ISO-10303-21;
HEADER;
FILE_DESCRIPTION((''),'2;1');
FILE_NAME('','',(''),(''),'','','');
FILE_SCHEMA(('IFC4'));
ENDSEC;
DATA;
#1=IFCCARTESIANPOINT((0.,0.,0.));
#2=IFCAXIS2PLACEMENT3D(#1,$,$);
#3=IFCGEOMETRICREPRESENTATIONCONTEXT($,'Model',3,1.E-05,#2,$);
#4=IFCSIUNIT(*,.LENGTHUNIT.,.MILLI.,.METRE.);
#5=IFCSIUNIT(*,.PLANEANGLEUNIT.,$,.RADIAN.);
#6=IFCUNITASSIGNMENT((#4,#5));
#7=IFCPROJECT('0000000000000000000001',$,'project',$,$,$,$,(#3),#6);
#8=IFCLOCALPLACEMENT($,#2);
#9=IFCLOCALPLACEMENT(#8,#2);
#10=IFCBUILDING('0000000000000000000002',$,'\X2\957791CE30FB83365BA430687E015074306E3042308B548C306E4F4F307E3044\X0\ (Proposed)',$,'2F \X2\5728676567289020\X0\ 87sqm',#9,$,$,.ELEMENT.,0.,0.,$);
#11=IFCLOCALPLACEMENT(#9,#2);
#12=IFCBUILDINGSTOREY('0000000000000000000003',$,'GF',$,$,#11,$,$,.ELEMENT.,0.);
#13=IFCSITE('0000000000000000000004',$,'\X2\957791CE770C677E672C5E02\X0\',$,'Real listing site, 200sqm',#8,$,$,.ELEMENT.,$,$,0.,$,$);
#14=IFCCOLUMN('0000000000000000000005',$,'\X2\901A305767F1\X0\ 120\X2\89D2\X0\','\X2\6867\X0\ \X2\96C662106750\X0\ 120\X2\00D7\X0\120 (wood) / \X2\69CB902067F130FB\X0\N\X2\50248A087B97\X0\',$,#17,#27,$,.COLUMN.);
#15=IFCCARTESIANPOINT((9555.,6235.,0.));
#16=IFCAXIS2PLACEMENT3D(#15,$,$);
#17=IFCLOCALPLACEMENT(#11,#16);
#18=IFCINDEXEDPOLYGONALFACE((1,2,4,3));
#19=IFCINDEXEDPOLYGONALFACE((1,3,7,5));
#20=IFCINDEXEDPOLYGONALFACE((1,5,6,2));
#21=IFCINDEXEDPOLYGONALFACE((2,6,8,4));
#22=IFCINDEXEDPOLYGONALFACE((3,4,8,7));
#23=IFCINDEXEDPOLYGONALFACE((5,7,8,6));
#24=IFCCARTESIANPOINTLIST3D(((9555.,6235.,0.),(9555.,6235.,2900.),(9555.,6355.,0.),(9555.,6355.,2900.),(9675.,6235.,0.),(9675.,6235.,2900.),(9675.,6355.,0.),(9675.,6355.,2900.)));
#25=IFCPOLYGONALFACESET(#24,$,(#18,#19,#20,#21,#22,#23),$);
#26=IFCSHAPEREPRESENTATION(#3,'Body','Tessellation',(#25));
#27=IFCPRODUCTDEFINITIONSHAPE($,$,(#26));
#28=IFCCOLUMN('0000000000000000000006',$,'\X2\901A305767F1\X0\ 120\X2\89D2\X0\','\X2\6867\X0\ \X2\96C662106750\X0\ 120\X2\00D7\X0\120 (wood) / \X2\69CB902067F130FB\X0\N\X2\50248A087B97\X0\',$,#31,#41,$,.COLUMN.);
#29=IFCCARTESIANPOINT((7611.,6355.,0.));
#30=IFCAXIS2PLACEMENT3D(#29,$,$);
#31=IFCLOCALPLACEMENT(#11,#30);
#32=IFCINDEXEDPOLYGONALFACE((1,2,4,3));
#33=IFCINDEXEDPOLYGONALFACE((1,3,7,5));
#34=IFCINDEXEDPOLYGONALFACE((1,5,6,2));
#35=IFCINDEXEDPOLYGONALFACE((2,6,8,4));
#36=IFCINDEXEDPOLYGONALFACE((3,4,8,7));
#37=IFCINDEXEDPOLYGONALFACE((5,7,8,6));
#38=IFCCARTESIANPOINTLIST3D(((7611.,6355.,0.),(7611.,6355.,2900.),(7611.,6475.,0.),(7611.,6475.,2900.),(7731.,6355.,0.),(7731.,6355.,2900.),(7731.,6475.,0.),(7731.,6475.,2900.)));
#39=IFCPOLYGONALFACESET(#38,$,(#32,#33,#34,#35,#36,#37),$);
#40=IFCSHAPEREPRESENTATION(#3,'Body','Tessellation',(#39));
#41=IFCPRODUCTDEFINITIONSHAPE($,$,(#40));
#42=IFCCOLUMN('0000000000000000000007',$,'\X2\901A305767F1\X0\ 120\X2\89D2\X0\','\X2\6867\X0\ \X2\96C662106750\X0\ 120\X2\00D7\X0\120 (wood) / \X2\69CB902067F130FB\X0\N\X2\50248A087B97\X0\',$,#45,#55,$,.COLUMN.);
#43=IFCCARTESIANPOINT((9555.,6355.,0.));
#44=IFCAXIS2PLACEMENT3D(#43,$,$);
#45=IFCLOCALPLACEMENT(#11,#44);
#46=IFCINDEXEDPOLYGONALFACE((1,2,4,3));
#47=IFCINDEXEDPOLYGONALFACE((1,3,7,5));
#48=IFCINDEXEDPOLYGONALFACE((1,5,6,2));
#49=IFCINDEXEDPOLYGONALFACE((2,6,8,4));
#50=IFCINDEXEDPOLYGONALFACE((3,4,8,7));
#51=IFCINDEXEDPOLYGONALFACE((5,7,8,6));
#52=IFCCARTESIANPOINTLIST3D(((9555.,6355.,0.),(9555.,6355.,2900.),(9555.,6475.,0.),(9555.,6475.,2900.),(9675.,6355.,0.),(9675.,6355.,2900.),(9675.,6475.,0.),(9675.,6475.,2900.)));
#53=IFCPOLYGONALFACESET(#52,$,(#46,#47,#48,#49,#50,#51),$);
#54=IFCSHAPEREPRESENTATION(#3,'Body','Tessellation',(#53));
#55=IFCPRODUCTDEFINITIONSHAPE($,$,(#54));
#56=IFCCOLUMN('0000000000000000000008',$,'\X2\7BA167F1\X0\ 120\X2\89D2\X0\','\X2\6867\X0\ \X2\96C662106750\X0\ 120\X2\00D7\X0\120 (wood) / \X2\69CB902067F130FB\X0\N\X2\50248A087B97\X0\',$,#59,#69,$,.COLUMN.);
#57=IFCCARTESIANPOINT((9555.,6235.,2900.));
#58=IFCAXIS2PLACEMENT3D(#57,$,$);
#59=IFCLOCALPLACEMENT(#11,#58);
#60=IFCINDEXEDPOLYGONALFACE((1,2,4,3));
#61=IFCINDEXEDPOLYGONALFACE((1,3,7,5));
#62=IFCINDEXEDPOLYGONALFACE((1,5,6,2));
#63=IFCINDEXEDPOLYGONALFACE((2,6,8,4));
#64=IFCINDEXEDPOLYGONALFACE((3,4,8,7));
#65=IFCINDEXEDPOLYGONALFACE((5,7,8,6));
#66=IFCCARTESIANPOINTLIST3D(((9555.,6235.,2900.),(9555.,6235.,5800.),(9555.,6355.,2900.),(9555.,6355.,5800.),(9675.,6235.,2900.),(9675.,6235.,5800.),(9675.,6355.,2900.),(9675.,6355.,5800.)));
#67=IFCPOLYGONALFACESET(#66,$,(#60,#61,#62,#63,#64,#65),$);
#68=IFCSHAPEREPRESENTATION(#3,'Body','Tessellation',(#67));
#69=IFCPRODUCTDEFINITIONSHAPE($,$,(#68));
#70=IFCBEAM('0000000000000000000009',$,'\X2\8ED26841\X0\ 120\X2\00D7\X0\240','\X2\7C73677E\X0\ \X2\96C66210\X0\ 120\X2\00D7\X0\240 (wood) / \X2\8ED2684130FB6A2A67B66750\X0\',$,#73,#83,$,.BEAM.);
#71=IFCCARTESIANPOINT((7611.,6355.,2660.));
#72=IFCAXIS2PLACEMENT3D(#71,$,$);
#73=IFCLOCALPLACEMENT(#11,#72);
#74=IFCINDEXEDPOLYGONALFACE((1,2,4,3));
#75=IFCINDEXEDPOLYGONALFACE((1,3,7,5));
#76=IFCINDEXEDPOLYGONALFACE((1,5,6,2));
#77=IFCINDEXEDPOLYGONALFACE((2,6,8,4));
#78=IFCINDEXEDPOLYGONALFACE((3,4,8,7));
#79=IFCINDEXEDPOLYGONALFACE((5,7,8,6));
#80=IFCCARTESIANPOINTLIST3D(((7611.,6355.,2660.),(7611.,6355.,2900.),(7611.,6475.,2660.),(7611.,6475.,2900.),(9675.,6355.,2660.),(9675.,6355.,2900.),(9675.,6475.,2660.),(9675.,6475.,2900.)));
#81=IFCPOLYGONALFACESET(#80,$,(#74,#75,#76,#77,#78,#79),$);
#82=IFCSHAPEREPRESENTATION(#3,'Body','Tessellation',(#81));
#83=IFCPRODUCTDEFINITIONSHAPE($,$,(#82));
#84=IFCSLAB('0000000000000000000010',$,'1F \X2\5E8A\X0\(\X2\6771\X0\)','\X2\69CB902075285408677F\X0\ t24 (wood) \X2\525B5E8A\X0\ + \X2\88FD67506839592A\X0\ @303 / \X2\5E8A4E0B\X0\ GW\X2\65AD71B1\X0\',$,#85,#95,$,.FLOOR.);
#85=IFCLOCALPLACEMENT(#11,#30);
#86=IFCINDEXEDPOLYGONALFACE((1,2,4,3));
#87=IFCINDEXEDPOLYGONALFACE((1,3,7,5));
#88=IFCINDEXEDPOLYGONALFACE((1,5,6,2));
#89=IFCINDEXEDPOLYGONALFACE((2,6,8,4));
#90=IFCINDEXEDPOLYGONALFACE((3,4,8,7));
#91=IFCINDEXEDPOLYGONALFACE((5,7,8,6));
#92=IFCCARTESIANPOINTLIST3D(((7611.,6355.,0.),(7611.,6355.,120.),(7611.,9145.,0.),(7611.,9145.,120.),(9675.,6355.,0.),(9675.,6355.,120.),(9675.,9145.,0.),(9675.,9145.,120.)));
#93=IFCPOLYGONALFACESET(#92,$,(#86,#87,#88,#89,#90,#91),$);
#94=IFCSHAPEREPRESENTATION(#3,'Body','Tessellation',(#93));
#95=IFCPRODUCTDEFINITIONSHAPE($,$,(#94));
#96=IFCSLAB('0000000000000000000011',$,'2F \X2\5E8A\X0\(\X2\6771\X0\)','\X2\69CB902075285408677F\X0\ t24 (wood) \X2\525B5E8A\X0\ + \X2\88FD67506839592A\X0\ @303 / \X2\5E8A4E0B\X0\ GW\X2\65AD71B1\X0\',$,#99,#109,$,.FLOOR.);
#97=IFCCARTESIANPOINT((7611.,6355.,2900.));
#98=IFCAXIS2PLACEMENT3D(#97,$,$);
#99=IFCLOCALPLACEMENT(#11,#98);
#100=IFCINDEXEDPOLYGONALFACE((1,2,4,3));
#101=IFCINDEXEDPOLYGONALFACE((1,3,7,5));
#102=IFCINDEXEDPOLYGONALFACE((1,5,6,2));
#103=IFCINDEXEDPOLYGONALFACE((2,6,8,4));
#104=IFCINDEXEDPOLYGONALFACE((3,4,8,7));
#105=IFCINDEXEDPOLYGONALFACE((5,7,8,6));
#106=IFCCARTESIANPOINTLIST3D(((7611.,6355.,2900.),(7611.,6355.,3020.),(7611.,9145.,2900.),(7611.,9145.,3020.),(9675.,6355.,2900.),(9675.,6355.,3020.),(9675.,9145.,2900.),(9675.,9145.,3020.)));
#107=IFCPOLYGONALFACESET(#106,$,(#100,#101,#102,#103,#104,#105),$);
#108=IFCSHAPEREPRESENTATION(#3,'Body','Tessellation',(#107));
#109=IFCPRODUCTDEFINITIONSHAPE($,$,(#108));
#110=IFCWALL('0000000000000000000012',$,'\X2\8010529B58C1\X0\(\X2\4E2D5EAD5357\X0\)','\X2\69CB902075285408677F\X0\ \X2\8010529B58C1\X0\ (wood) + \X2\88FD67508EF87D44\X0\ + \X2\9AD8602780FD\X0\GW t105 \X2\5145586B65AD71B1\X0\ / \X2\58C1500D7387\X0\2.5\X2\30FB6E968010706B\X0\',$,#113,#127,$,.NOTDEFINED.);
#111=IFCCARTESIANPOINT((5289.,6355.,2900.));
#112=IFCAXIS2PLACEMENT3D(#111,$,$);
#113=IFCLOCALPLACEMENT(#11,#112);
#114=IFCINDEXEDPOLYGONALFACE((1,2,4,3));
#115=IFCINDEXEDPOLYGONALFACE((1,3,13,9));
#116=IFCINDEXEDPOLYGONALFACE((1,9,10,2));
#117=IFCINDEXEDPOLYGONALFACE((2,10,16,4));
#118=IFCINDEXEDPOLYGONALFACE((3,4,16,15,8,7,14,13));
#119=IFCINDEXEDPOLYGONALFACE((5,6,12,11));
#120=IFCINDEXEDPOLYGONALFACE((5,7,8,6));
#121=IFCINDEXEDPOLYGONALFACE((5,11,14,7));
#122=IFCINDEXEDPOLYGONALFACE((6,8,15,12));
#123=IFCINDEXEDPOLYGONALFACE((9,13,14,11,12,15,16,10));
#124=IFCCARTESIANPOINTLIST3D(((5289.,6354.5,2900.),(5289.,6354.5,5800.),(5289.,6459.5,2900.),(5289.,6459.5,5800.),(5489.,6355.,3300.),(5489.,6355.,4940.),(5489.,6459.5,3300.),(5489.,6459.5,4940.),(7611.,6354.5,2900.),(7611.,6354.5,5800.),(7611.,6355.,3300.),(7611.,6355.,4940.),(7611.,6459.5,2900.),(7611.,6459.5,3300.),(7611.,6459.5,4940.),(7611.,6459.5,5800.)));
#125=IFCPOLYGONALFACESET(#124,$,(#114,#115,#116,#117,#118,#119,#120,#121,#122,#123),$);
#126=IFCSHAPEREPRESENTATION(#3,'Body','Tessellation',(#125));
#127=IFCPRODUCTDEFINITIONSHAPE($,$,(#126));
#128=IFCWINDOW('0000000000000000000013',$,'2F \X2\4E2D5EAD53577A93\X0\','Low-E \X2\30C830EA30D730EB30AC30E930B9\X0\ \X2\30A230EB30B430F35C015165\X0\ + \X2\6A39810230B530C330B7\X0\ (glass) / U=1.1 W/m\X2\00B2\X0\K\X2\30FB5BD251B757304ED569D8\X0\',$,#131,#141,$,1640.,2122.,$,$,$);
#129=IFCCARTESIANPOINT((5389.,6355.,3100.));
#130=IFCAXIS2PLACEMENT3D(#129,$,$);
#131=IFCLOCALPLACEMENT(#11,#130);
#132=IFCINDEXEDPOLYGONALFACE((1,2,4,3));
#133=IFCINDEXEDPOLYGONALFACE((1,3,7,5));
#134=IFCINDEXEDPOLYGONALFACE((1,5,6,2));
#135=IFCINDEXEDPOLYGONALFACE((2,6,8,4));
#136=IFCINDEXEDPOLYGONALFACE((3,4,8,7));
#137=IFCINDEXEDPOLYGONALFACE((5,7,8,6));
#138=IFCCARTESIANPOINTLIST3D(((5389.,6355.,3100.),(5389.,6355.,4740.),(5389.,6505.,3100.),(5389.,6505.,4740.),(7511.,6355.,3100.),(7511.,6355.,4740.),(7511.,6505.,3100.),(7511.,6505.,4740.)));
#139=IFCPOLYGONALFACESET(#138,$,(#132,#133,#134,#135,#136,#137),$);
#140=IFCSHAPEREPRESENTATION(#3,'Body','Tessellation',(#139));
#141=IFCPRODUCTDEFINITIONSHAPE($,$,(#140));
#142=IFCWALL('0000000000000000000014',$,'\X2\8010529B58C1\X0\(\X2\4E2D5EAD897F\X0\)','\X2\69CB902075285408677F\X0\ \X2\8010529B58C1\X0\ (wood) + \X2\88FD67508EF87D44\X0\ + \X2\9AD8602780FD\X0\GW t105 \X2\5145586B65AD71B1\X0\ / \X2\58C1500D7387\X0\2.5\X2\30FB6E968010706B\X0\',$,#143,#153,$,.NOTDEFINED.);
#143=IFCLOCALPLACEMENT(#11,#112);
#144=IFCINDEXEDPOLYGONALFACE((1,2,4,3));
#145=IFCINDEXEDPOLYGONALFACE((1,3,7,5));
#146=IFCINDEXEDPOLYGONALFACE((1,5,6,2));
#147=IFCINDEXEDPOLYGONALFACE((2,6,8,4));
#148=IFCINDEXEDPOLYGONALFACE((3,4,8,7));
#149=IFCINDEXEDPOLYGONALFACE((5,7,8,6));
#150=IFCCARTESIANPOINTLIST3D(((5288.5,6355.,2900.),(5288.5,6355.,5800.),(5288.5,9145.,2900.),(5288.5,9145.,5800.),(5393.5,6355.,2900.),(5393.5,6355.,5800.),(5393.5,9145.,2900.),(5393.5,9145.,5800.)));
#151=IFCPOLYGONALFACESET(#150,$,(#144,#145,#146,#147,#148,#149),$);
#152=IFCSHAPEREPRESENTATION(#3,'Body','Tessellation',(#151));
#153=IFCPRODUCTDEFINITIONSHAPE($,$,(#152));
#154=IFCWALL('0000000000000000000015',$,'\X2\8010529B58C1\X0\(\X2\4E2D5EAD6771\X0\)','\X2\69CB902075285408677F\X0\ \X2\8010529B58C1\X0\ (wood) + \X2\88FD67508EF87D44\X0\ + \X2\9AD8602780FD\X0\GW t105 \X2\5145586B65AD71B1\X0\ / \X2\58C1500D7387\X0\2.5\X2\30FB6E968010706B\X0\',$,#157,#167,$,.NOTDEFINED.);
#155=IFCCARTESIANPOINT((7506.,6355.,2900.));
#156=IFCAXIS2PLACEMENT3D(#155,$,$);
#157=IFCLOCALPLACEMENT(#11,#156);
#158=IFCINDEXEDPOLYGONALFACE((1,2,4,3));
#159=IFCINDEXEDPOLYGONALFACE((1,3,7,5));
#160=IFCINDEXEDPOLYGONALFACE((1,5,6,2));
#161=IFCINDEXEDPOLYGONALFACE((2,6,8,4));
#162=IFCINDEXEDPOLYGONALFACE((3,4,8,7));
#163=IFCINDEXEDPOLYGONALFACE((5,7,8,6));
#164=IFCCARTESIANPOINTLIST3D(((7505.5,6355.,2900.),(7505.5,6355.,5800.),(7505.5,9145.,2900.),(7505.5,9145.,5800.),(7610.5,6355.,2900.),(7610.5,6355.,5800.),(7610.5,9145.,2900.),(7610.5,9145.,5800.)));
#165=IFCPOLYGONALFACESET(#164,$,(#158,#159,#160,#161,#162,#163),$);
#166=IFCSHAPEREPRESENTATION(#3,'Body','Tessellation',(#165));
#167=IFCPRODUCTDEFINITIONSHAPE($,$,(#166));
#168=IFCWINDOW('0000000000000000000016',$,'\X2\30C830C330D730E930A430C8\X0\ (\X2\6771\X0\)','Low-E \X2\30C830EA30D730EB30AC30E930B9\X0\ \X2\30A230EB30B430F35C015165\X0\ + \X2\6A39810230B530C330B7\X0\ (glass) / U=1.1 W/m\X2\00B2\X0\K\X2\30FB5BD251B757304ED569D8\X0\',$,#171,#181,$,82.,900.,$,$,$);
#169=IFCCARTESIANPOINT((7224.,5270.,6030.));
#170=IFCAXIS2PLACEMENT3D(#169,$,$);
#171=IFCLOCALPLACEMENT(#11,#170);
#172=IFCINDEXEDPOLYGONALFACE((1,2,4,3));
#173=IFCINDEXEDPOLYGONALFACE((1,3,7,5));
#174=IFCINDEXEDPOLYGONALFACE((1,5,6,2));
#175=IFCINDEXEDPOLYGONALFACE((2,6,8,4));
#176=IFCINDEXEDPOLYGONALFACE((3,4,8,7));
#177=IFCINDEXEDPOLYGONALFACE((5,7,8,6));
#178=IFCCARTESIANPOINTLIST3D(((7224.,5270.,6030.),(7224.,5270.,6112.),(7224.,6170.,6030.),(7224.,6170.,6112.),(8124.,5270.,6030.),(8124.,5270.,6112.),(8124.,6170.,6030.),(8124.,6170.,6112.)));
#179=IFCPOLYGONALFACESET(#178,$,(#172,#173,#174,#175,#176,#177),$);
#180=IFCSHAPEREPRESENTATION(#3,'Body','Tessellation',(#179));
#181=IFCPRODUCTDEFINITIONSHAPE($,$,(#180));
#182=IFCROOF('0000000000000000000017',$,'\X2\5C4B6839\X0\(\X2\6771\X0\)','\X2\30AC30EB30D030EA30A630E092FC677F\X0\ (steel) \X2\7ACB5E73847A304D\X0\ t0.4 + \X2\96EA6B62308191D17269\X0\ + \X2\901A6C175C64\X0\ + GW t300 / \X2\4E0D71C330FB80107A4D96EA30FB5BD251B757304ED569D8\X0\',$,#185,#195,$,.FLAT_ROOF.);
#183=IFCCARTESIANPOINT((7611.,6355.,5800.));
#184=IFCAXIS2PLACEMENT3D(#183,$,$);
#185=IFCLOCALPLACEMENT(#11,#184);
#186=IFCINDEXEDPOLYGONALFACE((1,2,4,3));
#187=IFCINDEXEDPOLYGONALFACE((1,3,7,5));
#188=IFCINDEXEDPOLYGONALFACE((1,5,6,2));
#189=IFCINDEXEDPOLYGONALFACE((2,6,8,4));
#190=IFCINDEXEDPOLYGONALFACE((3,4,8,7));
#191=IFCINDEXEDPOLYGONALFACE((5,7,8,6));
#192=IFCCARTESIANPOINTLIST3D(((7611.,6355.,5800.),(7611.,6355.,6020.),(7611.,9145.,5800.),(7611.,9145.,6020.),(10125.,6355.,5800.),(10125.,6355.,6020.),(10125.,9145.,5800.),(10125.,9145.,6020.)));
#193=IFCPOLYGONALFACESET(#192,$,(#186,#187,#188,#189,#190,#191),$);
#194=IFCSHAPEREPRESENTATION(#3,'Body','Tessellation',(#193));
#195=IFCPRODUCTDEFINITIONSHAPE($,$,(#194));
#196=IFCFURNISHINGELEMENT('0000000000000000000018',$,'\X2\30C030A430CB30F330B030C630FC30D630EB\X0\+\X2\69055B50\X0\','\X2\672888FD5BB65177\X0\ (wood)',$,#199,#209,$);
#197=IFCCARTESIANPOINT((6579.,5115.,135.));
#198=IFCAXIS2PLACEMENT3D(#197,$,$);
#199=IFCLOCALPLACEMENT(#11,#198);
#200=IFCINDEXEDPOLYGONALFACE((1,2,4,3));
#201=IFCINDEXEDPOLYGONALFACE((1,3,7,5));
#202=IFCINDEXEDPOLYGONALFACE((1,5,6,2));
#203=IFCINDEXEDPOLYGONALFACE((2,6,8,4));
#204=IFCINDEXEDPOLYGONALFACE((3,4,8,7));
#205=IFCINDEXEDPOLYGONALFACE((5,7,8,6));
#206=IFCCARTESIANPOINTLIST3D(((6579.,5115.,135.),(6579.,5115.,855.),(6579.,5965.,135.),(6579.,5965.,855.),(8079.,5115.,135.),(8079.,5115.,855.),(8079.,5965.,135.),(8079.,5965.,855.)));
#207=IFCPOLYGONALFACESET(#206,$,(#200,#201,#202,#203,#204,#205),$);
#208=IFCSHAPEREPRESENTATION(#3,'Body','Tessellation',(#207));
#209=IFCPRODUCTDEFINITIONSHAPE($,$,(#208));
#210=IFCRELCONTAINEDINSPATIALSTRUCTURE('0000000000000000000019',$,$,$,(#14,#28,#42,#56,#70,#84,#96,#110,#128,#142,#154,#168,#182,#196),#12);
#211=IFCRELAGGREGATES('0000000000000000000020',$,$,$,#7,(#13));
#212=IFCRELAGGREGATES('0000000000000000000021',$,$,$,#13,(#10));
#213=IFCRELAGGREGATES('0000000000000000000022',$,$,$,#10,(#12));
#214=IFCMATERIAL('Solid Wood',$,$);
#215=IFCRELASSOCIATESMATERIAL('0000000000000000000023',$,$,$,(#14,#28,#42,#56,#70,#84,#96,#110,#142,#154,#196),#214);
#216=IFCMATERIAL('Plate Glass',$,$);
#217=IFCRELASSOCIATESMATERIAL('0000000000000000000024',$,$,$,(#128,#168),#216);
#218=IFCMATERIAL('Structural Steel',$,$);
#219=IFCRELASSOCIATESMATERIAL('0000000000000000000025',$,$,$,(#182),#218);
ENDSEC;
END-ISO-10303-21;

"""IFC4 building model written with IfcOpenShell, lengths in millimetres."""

from ifc_helpers import new_model, si_unit, frame, frame_2d, origin, place, context, project, spatial, rectangle, extrude, material, element, fill, save


model = new_model("IFC4")

# Units and contexts
model_context = context("Model", 3, precision=1e-05, world=origin())
ifc_project = project(units=[si_unit("LENGTHUNIT", "METRE", prefix="MILLI"), si_unit("PLANEANGLEUNIT", "RADIAN")], contexts=[model_context])

# Site, building, storey
site_placement = place(None, origin())
site = spatial("IfcSite", under=ifc_project, at=site_placement, Name="長野県松本市", ObjectType="Real listing site, 200sqm", CompositionType="ELEMENT", RefElevation=0.0)
building_placement = place(site_placement, origin())
building = spatial("IfcBuilding", under=site, at=building_placement, Name="長野・茶室と縁側のある和の住まい (Proposed)", ObjectType="2F 在来木造 87sqm", CompositionType="ELEMENT", ElevationOfRefHeight=0.0, ElevationOfTerrain=0.0)
storey_placement = place(building_placement, origin())
storey = spatial("IfcBuildingStorey", under=building, at=storey_placement, Name="GF", CompositionType="ELEMENT", Elevation=0.0)

# Columns
ifc_material_1 = material(Name="Solid Wood")
column_1_placement = place(storey_placement, frame((9555.0, 6235.0, 0.0)))
element("IfcColumn", 1, at=column_1_placement, inside=storey, material=ifc_material_1, Name="通し柱 120角", Description="桧 集成材 120×120 (wood) / 構造柱・N値計算", PredefinedType="COLUMN", context=model_context, shape_type="SweptSolid", body=[
    extrude(rectangle(XDim=120.0, YDim=120.0, at=frame_2d((60.0, 60.0))), frame((9555.0, 6235.0, 0.0)), (0.0, 0.0, 1.0), 2900.0),
])
column_2_placement = place(storey_placement, frame((7611.0, 6355.0, 0.0)))
element("IfcColumn", 2, at=column_2_placement, inside=storey, material=ifc_material_1, Name="通し柱 120角", Description="桧 集成材 120×120 (wood) / 構造柱・N値計算", PredefinedType="COLUMN", context=model_context, shape_type="SweptSolid", body=[
    extrude(rectangle(XDim=120.0, YDim=120.0, at=frame_2d((60.0, 60.0))), frame((7611.0, 6355.0, 0.0)), (0.0, 0.0, 1.0), 2900.0),
])
column_3_placement = place(storey_placement, frame((9555.0, 6355.0, 0.0)))
element("IfcColumn", 3, at=column_3_placement, inside=storey, material=ifc_material_1, Name="通し柱 120角", Description="桧 集成材 120×120 (wood) / 構造柱・N値計算", PredefinedType="COLUMN", context=model_context, shape_type="SweptSolid", body=[
    extrude(rectangle(XDim=120.0, YDim=120.0, at=frame_2d((60.0, 60.0))), frame((9555.0, 6355.0, 0.0)), (0.0, 0.0, 1.0), 2900.0),
])
column_4_placement = place(storey_placement, frame((9555.0, 6235.0, 2900.0)))
element("IfcColumn", 4, at=column_4_placement, inside=storey, material=ifc_material_1, Name="管柱 120角", Description="桧 集成材 120×120 (wood) / 構造柱・N値計算", PredefinedType="COLUMN", context=model_context, shape_type="SweptSolid", body=[
    extrude(rectangle(XDim=120.0, YDim=120.0, at=frame_2d((60.0, 60.0))), frame((9555.0, 6235.0, 2900.0)), (0.0, 0.0, 1.0), 2900.0),
])

# Beam
beam_1_placement = place(storey_placement, frame((7611.0, 6355.0, 2660.0)))
element("IfcBeam", 5, at=beam_1_placement, inside=storey, material=ifc_material_1, Name="軒桁 120×240", Description="米松 集成 120×240 (wood) / 軒桁・横架材", PredefinedType="BEAM", context=model_context, shape_type="SweptSolid", body=[
    extrude(rectangle(XDim=2064.0, YDim=120.0, at=frame_2d((1032.0, 60.0))), frame((7611.0, 6355.0, 2660.0)), (0.0, 0.0, 1.0), 240.0),
])

# Slabs
slab_1_placement = place(storey_placement, frame((7611.0, 6355.0, 0.0)))
element("IfcSlab", 6, at=slab_1_placement, inside=storey, material=ifc_material_1, Name="1F 床(東)", Description="構造用合板 t24 (wood) 剛床 + 製材根太 @303 / 床下 GW断熱", PredefinedType="FLOOR", context=model_context, shape_type="SweptSolid", body=[
    extrude(rectangle(XDim=2064.0, YDim=2790.0, at=frame_2d((1032.0, 1395.0))), frame((7611.0, 6355.0, 0.0)), (0.0, 0.0, 1.0), 120.0),
])
slab_2_placement = place(storey_placement, frame((7611.0, 6355.0, 2900.0)))
element("IfcSlab", 7, at=slab_2_placement, inside=storey, material=ifc_material_1, Name="2F 床(東)", Description="構造用合板 t24 (wood) 剛床 + 製材根太 @303 / 床下 GW断熱", PredefinedType="FLOOR", context=model_context, shape_type="SweptSolid", body=[
    extrude(rectangle(XDim=2064.0, YDim=2790.0, at=frame_2d((1032.0, 1395.0))), frame((7611.0, 6355.0, 2900.0)), (0.0, 0.0, 1.0), 120.0),
])

# Wall, opening, window
wall_1_placement = place(storey_placement, frame((5289.0, 6355.0, 2900.0)))
wall_1 = element("IfcWall", 8, at=wall_1_placement, inside=storey, material=ifc_material_1, Name="耐力壁(中庭南)", Description="構造用合板 耐力壁 (wood) + 製材軸組 + 高性能GW t105 充填断熱 / 壁倍率2.5・準耐火", PredefinedType="NOTDEFINED", context=model_context, shape_type="SweptSolid", body=[
    extrude(rectangle(XDim=2322.0, YDim=105.0, at=frame_2d((1161.0, 52.0))), frame((5289.0, 6355.0, 2900.0)), (0.0, 0.0, 1.0), 2900.0),
])
opening_placement = place(storey_placement, frame((5389.0, 6355.0, 3100.0)))
opening = element("IfcOpeningElement", 9, at=opening_placement, cuts=wall_1, PredefinedType="NOTDEFINED", context=model_context, shape_type="SweptSolid", body=[
    extrude(rectangle(XDim=2122.0, YDim=150.0, at=frame_2d((1061.0, 75.0))), frame((5389.0, 6355.0, 3100.0)), (0.0, 0.0, 1.0), 1640.0),
])
ifc_material_2 = material(Name="Plate Glass")
window_1_placement = place(storey_placement, frame((5389.0, 6355.0, 3100.0)))
window_1 = element("IfcWindow", 10, at=window_1_placement, inside=storey, material=ifc_material_2, Name="2F 中庭南窓", Description="Low-E トリプルガラス アルゴン封入 + 樹脂サッシ (glass) / U=1.1 W/m²K・寒冷地仕様", OverallHeight=1640.0, OverallWidth=2122.0, context=model_context, shape_type="SweptSolid", body=[
    extrude(rectangle(XDim=2122.0, YDim=150.0, at=frame_2d((1061.0, 75.0))), frame((5389.0, 6355.0, 3100.0)), (0.0, 0.0, 1.0), 1640.0),
])
fill(opening, window_1)

# Walls
wall_2_placement = place(storey_placement, frame((5289.0, 6355.0, 2900.0)))
element("IfcWall", 11, at=wall_2_placement, inside=storey, material=ifc_material_1, Name="耐力壁(中庭西)", Description="構造用合板 耐力壁 (wood) + 製材軸組 + 高性能GW t105 充填断熱 / 壁倍率2.5・準耐火", PredefinedType="NOTDEFINED", context=model_context, shape_type="SweptSolid", body=[
    extrude(rectangle(XDim=105.0, YDim=2790.0, at=frame_2d((52.0, 1395.0))), frame((5289.0, 6355.0, 2900.0)), (0.0, 0.0, 1.0), 2900.0),
])
wall_3_placement = place(storey_placement, frame((7506.0, 6355.0, 2900.0)))
element("IfcWall", 12, at=wall_3_placement, inside=storey, material=ifc_material_1, Name="耐力壁(中庭東)", Description="構造用合板 耐力壁 (wood) + 製材軸組 + 高性能GW t105 充填断熱 / 壁倍率2.5・準耐火", PredefinedType="NOTDEFINED", context=model_context, shape_type="SweptSolid", body=[
    extrude(rectangle(XDim=105.0, YDim=2790.0, at=frame_2d((52.0, 1395.0))), frame((7506.0, 6355.0, 2900.0)), (0.0, 0.0, 1.0), 2900.0),
])

# Window
window_2_placement = place(storey_placement, frame((7224.0, 5270.0, 6030.0)))
element("IfcWindow", 13, at=window_2_placement, inside=storey, material=ifc_material_2, Name="トップライト (東)", Description="Low-E トリプルガラス アルゴン封入 + 樹脂サッシ (glass) / U=1.1 W/m²K・寒冷地仕様", OverallHeight=82.0, OverallWidth=900.0, context=model_context, shape_type="SweptSolid", body=[
    extrude(rectangle(XDim=900.0, YDim=900.0, at=frame_2d((450.0, 450.0))), frame((7224.0, 5270.0, 6030.0)), (0.0, 0.0, 1.0), 82.0),
])

# Roof
ifc_material_3 = material(Name="Structural Steel")
for number, where, name in (
    (14, (7611.0, 6355.0, 5800.0), "屋根(東)"),
):
    element("IfcRoof", number, at=place(storey_placement, frame(where)), inside=storey, material=ifc_material_3, Name=name, Description="ガルバリウム鋼板 (steel) 立平葺き t0.4 + 雪止め金物 + 通気層 + GW t300 / 不燃・耐積雪・寒冷地仕様", PredefinedType="FLAT_ROOF", context=model_context, shape_type="SweptSolid", body=[
        extrude(rectangle(XDim=2514.0, YDim=2790.0, at=frame_2d((1257.0, 1395.0))), frame((7611.0, 6355.0, 5800.0)), (0.0, 0.0, 1.0), 220.0),
    ])

# Furnishing element
furnishing_1_placement = place(storey_placement, frame((6579.0, 5115.0, 135.0)))
element("IfcFurnishingElement", 15, at=furnishing_1_placement, inside=storey, material=ifc_material_1, Name="ダイニングテーブル+椅子", Description="木製家具 (wood)", context=model_context, shape_type="SweptSolid", body=[
    extrude(rectangle(XDim=1500.0, YDim=850.0, at=frame_2d((750.0, 425.0))), frame((6579.0, 5115.0, 135.0)), (0.0, 0.0, 1.0), 720.0),
])

save(model, "model.ifc")
